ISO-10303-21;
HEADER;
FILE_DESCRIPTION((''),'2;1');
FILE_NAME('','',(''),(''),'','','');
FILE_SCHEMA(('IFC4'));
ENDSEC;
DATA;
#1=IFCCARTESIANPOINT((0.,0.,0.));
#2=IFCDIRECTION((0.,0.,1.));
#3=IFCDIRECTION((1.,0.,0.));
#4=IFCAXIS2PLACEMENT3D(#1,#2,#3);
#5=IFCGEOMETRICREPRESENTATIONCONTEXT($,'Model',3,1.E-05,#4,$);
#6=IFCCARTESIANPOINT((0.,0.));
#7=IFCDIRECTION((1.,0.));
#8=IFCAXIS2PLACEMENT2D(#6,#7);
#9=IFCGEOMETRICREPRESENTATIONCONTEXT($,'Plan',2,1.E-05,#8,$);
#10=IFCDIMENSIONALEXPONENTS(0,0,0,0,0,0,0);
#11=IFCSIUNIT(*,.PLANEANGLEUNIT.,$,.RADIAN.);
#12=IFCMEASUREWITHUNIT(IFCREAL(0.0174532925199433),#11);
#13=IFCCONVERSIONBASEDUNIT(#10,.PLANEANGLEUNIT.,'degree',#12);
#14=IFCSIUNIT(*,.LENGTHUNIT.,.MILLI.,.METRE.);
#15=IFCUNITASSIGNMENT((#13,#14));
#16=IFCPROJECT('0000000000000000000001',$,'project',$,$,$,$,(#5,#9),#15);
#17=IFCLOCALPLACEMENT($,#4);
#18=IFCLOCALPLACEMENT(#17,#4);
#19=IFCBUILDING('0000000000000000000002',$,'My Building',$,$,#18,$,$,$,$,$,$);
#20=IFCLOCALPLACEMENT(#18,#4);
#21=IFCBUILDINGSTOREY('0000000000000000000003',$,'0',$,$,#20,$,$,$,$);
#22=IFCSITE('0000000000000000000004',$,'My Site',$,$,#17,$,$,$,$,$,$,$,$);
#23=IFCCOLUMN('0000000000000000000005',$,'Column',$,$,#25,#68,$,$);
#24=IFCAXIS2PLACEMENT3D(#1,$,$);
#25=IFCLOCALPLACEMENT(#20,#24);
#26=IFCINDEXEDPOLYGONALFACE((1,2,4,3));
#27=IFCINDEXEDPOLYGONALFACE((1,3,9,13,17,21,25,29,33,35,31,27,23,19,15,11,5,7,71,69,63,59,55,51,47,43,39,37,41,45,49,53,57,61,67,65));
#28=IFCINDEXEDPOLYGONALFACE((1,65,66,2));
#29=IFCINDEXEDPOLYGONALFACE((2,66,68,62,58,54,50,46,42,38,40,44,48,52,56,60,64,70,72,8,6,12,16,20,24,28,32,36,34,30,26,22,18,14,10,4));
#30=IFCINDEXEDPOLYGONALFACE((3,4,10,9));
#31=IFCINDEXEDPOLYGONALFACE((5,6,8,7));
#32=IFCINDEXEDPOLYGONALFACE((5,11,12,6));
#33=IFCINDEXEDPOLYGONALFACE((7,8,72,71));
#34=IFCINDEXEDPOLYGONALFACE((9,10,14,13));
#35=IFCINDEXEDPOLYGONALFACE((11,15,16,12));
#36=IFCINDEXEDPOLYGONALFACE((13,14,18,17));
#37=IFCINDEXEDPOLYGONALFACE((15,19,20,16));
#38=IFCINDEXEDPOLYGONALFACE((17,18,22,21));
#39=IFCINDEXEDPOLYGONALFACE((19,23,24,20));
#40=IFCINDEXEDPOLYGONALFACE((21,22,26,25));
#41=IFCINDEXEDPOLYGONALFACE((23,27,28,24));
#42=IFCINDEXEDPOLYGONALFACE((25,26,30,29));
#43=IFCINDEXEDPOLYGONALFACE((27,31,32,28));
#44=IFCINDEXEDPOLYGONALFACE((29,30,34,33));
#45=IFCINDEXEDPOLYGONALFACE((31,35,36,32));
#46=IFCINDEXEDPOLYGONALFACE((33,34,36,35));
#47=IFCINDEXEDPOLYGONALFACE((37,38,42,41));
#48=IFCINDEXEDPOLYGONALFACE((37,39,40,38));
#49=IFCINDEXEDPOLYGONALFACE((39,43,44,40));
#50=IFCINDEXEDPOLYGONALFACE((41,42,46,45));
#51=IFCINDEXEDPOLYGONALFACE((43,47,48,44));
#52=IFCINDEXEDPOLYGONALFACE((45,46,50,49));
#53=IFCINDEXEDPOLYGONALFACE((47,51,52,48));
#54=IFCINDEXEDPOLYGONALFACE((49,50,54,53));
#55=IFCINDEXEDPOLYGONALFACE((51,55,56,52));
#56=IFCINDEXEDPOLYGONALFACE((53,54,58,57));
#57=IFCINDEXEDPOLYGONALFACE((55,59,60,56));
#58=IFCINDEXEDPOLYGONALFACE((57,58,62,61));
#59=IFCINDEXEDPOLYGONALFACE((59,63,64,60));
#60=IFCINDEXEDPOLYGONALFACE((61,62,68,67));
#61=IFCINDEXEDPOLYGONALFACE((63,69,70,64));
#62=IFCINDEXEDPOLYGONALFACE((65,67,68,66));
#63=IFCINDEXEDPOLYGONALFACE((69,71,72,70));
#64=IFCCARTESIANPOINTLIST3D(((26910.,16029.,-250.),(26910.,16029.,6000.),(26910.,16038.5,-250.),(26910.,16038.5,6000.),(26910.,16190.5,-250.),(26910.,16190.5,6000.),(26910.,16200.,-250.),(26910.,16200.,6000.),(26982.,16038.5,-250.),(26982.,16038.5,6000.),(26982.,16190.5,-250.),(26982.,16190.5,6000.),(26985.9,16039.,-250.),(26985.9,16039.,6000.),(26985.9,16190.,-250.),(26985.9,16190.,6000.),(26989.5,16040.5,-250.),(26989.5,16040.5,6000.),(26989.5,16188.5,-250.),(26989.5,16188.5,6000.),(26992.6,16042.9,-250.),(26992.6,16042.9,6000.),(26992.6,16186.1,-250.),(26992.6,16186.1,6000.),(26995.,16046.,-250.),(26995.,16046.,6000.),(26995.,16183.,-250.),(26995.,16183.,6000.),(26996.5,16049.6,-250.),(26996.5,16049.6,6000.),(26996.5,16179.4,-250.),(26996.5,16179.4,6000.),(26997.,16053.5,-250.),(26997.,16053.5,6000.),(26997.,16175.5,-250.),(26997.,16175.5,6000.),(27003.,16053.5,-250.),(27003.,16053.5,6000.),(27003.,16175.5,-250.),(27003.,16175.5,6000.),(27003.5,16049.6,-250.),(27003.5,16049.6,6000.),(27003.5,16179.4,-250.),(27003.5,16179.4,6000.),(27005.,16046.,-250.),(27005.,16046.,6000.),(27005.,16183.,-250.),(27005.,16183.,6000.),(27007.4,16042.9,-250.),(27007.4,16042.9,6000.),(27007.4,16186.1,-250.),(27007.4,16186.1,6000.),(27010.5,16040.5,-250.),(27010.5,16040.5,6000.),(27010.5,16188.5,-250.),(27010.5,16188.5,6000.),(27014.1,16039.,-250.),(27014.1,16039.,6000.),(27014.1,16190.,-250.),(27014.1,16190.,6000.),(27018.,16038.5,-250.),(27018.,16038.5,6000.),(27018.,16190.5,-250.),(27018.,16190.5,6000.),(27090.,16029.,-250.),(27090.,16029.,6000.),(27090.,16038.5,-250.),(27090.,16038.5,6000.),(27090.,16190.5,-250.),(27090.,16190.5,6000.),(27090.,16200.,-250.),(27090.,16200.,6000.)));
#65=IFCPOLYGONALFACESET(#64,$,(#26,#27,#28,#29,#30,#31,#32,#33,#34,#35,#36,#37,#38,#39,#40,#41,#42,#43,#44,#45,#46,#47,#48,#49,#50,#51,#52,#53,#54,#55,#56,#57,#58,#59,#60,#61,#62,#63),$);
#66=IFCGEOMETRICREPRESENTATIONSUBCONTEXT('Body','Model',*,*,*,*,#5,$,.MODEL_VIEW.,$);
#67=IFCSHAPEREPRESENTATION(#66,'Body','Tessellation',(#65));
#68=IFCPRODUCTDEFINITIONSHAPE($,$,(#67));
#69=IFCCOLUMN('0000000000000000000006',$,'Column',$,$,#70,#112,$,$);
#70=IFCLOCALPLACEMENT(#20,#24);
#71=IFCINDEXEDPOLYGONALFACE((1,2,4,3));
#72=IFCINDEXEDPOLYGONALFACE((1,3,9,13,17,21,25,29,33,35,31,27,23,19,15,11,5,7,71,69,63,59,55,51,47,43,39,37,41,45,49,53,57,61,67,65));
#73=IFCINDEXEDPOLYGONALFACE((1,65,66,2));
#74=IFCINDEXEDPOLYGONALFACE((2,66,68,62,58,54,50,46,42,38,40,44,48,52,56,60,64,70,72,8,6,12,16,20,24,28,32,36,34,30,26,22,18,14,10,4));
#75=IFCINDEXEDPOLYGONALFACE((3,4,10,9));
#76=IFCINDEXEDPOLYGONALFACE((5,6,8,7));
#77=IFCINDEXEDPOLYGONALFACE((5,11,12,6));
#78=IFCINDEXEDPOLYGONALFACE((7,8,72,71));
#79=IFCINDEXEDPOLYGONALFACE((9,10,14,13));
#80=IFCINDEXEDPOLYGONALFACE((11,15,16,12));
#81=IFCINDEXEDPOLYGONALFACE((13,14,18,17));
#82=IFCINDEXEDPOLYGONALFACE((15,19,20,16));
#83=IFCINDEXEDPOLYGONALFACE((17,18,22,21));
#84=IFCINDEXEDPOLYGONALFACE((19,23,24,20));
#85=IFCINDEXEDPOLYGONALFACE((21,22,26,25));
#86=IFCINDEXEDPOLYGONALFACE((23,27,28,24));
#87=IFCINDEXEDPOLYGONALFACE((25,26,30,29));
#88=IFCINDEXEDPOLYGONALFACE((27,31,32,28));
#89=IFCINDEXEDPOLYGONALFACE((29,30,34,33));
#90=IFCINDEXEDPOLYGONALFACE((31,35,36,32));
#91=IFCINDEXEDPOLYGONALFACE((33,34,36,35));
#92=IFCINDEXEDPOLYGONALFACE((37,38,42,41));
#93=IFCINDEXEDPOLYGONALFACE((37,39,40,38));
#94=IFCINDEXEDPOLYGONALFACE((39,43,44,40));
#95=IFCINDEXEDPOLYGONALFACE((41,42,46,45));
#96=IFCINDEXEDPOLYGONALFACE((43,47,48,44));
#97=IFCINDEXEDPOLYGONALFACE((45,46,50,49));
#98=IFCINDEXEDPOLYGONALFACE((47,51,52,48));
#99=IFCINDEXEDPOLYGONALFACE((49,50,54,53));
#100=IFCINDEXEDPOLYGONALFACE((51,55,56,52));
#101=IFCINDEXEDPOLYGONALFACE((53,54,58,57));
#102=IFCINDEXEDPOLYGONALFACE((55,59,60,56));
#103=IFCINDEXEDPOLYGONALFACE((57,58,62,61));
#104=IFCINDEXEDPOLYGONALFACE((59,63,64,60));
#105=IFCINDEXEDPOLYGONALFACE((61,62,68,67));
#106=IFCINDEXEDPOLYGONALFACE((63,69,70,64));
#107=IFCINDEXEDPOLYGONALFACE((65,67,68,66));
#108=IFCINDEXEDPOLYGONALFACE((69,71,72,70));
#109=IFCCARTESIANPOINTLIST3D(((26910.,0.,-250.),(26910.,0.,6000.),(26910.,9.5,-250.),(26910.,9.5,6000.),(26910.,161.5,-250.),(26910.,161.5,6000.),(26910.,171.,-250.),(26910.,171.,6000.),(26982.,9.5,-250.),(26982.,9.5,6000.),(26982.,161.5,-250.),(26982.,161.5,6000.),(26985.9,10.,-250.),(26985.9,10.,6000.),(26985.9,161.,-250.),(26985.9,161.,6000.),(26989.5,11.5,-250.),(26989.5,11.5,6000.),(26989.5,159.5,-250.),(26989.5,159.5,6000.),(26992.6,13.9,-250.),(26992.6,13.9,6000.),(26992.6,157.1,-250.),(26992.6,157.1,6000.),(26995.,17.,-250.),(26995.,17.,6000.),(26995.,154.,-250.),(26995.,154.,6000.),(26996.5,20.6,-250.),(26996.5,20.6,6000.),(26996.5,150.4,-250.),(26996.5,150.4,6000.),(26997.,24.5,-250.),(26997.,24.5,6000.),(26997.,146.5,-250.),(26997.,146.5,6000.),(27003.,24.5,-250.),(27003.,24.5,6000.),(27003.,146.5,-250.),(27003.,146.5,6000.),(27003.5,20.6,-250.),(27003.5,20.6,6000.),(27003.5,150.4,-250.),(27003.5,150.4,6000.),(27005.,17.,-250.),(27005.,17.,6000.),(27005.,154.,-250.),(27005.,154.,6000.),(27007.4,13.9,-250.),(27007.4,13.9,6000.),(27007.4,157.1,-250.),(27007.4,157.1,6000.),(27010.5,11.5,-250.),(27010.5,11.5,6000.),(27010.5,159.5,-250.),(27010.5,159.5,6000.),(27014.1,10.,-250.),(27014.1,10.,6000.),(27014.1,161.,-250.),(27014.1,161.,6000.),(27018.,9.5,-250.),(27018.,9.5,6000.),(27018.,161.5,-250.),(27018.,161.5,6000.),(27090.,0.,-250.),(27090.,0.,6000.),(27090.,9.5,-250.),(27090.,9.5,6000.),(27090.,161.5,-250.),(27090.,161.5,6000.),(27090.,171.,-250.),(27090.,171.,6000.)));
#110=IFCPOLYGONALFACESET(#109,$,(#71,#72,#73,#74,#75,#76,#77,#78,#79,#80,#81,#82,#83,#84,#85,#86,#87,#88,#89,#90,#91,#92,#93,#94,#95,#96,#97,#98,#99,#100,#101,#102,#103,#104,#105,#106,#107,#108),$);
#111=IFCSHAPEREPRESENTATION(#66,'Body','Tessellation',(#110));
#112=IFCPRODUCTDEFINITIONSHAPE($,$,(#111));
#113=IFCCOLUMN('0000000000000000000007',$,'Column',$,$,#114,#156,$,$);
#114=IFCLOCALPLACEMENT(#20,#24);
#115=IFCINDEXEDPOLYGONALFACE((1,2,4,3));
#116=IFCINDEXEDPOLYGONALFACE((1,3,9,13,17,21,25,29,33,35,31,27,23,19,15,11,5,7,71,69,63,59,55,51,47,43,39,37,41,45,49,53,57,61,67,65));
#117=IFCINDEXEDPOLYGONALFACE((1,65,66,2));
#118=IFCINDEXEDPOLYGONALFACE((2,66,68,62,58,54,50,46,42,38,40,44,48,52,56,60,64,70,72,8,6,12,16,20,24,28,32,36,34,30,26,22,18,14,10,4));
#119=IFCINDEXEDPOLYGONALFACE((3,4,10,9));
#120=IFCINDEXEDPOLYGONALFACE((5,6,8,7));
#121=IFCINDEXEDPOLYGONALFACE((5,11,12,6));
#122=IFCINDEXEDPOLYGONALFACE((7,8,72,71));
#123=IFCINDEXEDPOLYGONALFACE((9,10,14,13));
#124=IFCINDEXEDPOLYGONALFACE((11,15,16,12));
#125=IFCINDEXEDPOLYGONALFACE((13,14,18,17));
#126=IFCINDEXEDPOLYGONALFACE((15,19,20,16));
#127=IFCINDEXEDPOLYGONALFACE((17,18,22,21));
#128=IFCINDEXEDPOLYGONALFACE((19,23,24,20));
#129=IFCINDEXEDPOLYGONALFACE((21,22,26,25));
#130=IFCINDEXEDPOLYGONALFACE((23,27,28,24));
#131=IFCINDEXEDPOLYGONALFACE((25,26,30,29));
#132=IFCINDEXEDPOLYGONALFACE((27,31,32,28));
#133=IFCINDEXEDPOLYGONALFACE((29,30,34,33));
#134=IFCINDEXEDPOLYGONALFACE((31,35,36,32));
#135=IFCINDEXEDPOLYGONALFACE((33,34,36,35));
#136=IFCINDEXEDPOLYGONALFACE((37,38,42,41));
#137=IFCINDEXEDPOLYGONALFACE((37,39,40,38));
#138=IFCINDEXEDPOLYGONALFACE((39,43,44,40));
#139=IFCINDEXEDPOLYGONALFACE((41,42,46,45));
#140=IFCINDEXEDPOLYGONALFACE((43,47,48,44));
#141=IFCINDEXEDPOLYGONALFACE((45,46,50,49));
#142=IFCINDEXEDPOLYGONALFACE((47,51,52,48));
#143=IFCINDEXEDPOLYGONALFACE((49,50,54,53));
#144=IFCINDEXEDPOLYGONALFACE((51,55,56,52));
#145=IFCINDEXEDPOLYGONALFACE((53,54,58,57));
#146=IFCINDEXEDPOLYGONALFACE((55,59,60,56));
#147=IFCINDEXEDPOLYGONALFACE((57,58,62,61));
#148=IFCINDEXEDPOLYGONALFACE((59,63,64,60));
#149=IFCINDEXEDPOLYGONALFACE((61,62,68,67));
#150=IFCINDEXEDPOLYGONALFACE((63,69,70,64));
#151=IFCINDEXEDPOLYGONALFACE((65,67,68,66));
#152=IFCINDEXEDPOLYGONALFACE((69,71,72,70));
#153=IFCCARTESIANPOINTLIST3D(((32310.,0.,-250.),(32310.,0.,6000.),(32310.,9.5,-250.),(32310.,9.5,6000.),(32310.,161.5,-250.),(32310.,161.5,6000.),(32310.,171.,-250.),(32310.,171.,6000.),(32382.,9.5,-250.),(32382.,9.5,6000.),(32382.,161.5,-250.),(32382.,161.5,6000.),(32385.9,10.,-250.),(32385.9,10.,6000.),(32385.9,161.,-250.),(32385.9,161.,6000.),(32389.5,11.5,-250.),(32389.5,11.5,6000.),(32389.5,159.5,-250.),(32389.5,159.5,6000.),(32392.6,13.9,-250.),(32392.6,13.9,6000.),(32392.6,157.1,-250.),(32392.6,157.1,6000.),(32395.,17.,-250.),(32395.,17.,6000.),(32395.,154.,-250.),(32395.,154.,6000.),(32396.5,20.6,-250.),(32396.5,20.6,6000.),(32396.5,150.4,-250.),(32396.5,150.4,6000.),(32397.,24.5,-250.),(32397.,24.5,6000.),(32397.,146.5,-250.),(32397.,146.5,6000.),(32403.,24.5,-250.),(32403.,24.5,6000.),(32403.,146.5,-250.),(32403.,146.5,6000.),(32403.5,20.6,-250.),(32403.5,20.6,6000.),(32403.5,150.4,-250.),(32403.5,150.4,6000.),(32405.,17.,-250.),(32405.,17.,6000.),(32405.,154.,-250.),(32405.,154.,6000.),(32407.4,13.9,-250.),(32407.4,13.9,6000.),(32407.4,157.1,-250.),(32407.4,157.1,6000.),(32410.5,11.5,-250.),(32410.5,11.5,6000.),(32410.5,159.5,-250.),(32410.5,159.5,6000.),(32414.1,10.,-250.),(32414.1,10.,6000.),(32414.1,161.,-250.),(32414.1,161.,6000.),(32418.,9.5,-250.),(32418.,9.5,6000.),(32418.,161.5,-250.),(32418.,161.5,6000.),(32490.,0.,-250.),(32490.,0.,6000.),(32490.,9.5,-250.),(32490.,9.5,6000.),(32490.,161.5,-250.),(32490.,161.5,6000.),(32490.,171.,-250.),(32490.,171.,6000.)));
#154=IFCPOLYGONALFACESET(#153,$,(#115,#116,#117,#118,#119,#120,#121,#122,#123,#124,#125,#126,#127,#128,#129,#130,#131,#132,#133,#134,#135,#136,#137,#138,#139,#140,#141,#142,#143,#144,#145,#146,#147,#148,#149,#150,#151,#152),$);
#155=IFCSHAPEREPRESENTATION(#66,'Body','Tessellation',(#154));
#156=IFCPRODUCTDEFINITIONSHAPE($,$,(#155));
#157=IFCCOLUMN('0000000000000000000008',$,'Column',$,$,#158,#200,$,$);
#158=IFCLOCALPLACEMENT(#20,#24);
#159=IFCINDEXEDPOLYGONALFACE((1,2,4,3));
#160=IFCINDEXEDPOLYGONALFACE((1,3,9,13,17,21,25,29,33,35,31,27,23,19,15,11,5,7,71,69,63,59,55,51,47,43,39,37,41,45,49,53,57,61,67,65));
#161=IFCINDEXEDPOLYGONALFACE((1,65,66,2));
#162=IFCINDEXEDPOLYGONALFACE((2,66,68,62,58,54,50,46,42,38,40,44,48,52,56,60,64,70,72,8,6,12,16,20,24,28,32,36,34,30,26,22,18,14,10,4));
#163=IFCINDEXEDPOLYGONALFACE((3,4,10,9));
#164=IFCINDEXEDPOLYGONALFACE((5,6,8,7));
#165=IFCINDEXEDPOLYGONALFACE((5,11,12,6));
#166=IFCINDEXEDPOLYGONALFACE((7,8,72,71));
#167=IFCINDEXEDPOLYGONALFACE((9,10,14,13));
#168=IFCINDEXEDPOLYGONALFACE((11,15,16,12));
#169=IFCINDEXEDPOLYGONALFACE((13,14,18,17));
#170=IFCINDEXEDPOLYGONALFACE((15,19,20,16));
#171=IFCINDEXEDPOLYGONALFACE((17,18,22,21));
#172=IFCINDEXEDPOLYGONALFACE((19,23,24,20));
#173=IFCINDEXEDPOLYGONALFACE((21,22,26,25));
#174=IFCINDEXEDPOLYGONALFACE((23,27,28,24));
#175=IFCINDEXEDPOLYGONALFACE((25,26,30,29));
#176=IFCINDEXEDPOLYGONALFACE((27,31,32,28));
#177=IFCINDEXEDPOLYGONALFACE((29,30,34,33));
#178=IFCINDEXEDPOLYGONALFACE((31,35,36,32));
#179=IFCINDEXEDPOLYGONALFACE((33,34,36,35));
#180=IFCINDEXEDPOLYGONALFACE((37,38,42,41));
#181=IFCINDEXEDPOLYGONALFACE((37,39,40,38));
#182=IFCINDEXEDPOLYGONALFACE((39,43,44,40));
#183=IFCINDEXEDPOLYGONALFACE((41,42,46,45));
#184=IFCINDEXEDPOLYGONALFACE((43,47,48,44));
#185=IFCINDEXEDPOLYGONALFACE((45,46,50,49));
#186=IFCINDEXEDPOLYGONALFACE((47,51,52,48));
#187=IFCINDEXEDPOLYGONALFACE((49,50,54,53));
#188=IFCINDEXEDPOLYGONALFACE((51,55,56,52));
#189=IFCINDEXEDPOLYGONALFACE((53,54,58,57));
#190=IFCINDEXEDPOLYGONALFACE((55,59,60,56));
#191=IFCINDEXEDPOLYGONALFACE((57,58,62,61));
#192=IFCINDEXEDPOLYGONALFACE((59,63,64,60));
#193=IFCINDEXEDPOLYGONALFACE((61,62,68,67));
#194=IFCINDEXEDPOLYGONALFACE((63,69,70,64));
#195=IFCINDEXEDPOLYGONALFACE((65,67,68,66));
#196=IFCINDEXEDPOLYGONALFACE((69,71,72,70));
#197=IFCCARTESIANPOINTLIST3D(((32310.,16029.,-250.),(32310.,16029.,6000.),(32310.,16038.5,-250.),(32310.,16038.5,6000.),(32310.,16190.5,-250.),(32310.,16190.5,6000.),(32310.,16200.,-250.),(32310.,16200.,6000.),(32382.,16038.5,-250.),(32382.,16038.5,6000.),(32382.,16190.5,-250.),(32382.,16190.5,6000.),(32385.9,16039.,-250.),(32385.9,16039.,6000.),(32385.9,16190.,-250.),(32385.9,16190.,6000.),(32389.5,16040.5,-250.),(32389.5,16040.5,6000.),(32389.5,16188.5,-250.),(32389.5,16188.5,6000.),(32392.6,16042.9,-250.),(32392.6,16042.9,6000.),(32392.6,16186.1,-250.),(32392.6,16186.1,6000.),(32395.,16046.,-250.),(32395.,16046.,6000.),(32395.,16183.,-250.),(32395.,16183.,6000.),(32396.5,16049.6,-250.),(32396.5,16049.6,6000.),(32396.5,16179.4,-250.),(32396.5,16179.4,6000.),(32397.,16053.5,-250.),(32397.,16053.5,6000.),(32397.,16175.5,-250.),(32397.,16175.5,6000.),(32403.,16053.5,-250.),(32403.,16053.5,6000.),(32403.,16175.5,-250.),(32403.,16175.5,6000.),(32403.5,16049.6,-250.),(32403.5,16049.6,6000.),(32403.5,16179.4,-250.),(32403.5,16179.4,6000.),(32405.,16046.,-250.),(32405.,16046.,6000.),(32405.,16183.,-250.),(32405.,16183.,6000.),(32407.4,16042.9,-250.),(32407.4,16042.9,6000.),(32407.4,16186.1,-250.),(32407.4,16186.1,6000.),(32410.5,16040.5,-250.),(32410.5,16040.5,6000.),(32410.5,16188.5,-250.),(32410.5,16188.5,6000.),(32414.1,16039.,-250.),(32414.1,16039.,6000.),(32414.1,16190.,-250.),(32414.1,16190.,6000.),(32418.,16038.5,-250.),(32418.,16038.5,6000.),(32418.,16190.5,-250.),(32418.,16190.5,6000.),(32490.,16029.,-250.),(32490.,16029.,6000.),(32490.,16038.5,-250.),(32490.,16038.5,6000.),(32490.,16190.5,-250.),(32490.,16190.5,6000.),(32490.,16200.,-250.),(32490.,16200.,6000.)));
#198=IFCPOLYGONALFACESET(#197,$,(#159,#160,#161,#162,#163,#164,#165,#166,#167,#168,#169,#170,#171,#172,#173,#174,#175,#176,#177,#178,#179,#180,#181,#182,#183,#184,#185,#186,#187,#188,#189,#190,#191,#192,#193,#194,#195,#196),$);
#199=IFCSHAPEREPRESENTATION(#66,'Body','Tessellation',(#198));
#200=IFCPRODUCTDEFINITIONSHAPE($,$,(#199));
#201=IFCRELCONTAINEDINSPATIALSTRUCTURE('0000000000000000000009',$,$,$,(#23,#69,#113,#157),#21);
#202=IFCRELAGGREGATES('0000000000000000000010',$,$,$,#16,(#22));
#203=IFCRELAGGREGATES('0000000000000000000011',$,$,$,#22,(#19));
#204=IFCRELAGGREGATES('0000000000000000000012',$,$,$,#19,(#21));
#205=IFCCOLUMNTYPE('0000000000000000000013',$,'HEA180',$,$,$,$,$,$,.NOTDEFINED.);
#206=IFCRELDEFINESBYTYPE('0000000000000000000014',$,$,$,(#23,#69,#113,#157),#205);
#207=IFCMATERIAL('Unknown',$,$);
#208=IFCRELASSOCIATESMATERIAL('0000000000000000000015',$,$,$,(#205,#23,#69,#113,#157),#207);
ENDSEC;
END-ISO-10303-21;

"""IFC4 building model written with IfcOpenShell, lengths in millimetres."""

from ifc_helpers import new_model, entity, si_unit, converted_unit, frame, origin_with_axes, origin_2d_with_axis, place, context, subcontext, project, spatial, i_section, extrude, material, material_profile, profile_set, profile_usage, type_object, element, save


model = new_model("IFC4")

# Units and contexts
model_context = context("Model", 3, precision=1e-05, world=origin_with_axes())
plan_context = context("Plan", 2, precision=1e-05, world=origin_2d_with_axis())
body_context = subcontext(model_context, "Body", "Model", "MODEL_VIEW")
ifc_project = project(units=[converted_unit("PLANEANGLEUNIT", "degree", entity("IfcReal", 0.0174532925199433), si_unit("PLANEANGLEUNIT", "RADIAN"), dimensions=[0, 0, 0, 0, 0, 0, 0]), si_unit("LENGTHUNIT", "METRE", prefix="MILLI")], contexts=[model_context, plan_context])

# Site, building, storey
site_placement = place(None, origin_with_axes())
site = spatial("IfcSite", under=ifc_project, at=site_placement, Name="My Site")
building_placement = place(site_placement, origin_with_axes())
building = spatial("IfcBuilding", under=site, at=building_placement, Name="My Building")
storey_placement = place(building_placement, origin_with_axes())
storey = spatial("IfcBuildingStorey", under=building, at=storey_placement, Name="0")

# Columns
ifc_material = material(Name="Unknown")
ifc_material_profile_1 = material_profile(ifc_material, i_section(OverallWidth=180.0, OverallDepth=171.0, WebThickness=6.0, FlangeThickness=9.5, FilletRadius=15.0))
ifc_profile_set_1 = profile_set([ifc_material_profile_1])
column_type = type_object("IfcColumnType", Name="HEA180", PredefinedType="NOTDEFINED", material=ifc_profile_set_1)
ifc_profile_usage_1 = profile_usage(ifc_profile_set_1, cardinal=8)
column_1_placement = place(storey_placement, frame((27000.0, 16200.0, -250.0), z_axis=(0.0, 0.0, 1.0), x_axis=(1.0, 0.0, 0.0)))
element("IfcColumn", 1, at=column_1_placement, inside=storey, type_object=column_type, material=ifc_profile_usage_1, Name="Column", context=body_context, shape_type="SweptSolid", body=[
    extrude(i_section(OverallWidth=180.0, OverallDepth=171.0, WebThickness=6.0, FlangeThickness=9.5, FilletRadius=15.0), frame((0.0, -85.5, 0.0), z_axis=(0.0, 0.0, 1.0), x_axis=(1.0, 0.0, 0.0)), (0.0, 0.0, 1.0), 6250.0),
])
ifc_profile_usage_2 = profile_usage(ifc_profile_set_1, cardinal=2)
column_2_placement = place(storey_placement, frame((27000.0, 0.0, -250.0), z_axis=(0.0, 0.0, 1.0), x_axis=(1.0, 0.0, 0.0)))
element("IfcColumn", 2, at=column_2_placement, inside=storey, type_object=column_type, material=ifc_profile_usage_2, Name="Column", context=body_context, shape_type="SweptSolid", body=[
    extrude(i_section(OverallWidth=180.0, OverallDepth=171.0, WebThickness=6.0, FlangeThickness=9.5, FilletRadius=15.0), frame((0.0, 85.5, 0.0), z_axis=(0.0, 0.0, 1.0), x_axis=(1.0, 0.0, 0.0)), (0.0, 0.0, 1.0), 6250.0),
])
ifc_profile_usage_3 = profile_usage(ifc_profile_set_1, cardinal=2)
column_3_placement = place(storey_placement, frame((32400.0, 0.0, -250.0), z_axis=(0.0, 0.0, 1.0), x_axis=(1.0, 0.0, 0.0)))
element("IfcColumn", 3, at=column_3_placement, inside=storey, type_object=column_type, material=ifc_profile_usage_3, Name="Column", context=body_context, shape_type="SweptSolid", body=[
    extrude(i_section(OverallWidth=180.0, OverallDepth=171.0, WebThickness=6.0, FlangeThickness=9.5, FilletRadius=15.0), frame((0.0, 85.5, 0.0), z_axis=(0.0, 0.0, 1.0), x_axis=(1.0, 0.0, 0.0)), (0.0, 0.0, 1.0), 6250.0),
])
ifc_profile_usage_4 = profile_usage(ifc_profile_set_1, cardinal=8)
column_4_placement = place(storey_placement, frame((32400.0, 16200.0, -250.0), z_axis=(0.0, 0.0, 1.0), x_axis=(1.0, 0.0, 0.0)))
element("IfcColumn", 4, at=column_4_placement, inside=storey, type_object=column_type, material=ifc_profile_usage_4, Name="Column", context=body_context, shape_type="SweptSolid", body=[
    extrude(i_section(OverallWidth=180.0, OverallDepth=171.0, WebThickness=6.0, FlangeThickness=9.5, FilletRadius=15.0), frame((0.0, -85.5, 0.0), z_axis=(0.0, 0.0, 1.0), x_axis=(1.0, 0.0, 0.0)), (0.0, 0.0, 1.0), 6250.0),
])

save(model, "model.ifc")
